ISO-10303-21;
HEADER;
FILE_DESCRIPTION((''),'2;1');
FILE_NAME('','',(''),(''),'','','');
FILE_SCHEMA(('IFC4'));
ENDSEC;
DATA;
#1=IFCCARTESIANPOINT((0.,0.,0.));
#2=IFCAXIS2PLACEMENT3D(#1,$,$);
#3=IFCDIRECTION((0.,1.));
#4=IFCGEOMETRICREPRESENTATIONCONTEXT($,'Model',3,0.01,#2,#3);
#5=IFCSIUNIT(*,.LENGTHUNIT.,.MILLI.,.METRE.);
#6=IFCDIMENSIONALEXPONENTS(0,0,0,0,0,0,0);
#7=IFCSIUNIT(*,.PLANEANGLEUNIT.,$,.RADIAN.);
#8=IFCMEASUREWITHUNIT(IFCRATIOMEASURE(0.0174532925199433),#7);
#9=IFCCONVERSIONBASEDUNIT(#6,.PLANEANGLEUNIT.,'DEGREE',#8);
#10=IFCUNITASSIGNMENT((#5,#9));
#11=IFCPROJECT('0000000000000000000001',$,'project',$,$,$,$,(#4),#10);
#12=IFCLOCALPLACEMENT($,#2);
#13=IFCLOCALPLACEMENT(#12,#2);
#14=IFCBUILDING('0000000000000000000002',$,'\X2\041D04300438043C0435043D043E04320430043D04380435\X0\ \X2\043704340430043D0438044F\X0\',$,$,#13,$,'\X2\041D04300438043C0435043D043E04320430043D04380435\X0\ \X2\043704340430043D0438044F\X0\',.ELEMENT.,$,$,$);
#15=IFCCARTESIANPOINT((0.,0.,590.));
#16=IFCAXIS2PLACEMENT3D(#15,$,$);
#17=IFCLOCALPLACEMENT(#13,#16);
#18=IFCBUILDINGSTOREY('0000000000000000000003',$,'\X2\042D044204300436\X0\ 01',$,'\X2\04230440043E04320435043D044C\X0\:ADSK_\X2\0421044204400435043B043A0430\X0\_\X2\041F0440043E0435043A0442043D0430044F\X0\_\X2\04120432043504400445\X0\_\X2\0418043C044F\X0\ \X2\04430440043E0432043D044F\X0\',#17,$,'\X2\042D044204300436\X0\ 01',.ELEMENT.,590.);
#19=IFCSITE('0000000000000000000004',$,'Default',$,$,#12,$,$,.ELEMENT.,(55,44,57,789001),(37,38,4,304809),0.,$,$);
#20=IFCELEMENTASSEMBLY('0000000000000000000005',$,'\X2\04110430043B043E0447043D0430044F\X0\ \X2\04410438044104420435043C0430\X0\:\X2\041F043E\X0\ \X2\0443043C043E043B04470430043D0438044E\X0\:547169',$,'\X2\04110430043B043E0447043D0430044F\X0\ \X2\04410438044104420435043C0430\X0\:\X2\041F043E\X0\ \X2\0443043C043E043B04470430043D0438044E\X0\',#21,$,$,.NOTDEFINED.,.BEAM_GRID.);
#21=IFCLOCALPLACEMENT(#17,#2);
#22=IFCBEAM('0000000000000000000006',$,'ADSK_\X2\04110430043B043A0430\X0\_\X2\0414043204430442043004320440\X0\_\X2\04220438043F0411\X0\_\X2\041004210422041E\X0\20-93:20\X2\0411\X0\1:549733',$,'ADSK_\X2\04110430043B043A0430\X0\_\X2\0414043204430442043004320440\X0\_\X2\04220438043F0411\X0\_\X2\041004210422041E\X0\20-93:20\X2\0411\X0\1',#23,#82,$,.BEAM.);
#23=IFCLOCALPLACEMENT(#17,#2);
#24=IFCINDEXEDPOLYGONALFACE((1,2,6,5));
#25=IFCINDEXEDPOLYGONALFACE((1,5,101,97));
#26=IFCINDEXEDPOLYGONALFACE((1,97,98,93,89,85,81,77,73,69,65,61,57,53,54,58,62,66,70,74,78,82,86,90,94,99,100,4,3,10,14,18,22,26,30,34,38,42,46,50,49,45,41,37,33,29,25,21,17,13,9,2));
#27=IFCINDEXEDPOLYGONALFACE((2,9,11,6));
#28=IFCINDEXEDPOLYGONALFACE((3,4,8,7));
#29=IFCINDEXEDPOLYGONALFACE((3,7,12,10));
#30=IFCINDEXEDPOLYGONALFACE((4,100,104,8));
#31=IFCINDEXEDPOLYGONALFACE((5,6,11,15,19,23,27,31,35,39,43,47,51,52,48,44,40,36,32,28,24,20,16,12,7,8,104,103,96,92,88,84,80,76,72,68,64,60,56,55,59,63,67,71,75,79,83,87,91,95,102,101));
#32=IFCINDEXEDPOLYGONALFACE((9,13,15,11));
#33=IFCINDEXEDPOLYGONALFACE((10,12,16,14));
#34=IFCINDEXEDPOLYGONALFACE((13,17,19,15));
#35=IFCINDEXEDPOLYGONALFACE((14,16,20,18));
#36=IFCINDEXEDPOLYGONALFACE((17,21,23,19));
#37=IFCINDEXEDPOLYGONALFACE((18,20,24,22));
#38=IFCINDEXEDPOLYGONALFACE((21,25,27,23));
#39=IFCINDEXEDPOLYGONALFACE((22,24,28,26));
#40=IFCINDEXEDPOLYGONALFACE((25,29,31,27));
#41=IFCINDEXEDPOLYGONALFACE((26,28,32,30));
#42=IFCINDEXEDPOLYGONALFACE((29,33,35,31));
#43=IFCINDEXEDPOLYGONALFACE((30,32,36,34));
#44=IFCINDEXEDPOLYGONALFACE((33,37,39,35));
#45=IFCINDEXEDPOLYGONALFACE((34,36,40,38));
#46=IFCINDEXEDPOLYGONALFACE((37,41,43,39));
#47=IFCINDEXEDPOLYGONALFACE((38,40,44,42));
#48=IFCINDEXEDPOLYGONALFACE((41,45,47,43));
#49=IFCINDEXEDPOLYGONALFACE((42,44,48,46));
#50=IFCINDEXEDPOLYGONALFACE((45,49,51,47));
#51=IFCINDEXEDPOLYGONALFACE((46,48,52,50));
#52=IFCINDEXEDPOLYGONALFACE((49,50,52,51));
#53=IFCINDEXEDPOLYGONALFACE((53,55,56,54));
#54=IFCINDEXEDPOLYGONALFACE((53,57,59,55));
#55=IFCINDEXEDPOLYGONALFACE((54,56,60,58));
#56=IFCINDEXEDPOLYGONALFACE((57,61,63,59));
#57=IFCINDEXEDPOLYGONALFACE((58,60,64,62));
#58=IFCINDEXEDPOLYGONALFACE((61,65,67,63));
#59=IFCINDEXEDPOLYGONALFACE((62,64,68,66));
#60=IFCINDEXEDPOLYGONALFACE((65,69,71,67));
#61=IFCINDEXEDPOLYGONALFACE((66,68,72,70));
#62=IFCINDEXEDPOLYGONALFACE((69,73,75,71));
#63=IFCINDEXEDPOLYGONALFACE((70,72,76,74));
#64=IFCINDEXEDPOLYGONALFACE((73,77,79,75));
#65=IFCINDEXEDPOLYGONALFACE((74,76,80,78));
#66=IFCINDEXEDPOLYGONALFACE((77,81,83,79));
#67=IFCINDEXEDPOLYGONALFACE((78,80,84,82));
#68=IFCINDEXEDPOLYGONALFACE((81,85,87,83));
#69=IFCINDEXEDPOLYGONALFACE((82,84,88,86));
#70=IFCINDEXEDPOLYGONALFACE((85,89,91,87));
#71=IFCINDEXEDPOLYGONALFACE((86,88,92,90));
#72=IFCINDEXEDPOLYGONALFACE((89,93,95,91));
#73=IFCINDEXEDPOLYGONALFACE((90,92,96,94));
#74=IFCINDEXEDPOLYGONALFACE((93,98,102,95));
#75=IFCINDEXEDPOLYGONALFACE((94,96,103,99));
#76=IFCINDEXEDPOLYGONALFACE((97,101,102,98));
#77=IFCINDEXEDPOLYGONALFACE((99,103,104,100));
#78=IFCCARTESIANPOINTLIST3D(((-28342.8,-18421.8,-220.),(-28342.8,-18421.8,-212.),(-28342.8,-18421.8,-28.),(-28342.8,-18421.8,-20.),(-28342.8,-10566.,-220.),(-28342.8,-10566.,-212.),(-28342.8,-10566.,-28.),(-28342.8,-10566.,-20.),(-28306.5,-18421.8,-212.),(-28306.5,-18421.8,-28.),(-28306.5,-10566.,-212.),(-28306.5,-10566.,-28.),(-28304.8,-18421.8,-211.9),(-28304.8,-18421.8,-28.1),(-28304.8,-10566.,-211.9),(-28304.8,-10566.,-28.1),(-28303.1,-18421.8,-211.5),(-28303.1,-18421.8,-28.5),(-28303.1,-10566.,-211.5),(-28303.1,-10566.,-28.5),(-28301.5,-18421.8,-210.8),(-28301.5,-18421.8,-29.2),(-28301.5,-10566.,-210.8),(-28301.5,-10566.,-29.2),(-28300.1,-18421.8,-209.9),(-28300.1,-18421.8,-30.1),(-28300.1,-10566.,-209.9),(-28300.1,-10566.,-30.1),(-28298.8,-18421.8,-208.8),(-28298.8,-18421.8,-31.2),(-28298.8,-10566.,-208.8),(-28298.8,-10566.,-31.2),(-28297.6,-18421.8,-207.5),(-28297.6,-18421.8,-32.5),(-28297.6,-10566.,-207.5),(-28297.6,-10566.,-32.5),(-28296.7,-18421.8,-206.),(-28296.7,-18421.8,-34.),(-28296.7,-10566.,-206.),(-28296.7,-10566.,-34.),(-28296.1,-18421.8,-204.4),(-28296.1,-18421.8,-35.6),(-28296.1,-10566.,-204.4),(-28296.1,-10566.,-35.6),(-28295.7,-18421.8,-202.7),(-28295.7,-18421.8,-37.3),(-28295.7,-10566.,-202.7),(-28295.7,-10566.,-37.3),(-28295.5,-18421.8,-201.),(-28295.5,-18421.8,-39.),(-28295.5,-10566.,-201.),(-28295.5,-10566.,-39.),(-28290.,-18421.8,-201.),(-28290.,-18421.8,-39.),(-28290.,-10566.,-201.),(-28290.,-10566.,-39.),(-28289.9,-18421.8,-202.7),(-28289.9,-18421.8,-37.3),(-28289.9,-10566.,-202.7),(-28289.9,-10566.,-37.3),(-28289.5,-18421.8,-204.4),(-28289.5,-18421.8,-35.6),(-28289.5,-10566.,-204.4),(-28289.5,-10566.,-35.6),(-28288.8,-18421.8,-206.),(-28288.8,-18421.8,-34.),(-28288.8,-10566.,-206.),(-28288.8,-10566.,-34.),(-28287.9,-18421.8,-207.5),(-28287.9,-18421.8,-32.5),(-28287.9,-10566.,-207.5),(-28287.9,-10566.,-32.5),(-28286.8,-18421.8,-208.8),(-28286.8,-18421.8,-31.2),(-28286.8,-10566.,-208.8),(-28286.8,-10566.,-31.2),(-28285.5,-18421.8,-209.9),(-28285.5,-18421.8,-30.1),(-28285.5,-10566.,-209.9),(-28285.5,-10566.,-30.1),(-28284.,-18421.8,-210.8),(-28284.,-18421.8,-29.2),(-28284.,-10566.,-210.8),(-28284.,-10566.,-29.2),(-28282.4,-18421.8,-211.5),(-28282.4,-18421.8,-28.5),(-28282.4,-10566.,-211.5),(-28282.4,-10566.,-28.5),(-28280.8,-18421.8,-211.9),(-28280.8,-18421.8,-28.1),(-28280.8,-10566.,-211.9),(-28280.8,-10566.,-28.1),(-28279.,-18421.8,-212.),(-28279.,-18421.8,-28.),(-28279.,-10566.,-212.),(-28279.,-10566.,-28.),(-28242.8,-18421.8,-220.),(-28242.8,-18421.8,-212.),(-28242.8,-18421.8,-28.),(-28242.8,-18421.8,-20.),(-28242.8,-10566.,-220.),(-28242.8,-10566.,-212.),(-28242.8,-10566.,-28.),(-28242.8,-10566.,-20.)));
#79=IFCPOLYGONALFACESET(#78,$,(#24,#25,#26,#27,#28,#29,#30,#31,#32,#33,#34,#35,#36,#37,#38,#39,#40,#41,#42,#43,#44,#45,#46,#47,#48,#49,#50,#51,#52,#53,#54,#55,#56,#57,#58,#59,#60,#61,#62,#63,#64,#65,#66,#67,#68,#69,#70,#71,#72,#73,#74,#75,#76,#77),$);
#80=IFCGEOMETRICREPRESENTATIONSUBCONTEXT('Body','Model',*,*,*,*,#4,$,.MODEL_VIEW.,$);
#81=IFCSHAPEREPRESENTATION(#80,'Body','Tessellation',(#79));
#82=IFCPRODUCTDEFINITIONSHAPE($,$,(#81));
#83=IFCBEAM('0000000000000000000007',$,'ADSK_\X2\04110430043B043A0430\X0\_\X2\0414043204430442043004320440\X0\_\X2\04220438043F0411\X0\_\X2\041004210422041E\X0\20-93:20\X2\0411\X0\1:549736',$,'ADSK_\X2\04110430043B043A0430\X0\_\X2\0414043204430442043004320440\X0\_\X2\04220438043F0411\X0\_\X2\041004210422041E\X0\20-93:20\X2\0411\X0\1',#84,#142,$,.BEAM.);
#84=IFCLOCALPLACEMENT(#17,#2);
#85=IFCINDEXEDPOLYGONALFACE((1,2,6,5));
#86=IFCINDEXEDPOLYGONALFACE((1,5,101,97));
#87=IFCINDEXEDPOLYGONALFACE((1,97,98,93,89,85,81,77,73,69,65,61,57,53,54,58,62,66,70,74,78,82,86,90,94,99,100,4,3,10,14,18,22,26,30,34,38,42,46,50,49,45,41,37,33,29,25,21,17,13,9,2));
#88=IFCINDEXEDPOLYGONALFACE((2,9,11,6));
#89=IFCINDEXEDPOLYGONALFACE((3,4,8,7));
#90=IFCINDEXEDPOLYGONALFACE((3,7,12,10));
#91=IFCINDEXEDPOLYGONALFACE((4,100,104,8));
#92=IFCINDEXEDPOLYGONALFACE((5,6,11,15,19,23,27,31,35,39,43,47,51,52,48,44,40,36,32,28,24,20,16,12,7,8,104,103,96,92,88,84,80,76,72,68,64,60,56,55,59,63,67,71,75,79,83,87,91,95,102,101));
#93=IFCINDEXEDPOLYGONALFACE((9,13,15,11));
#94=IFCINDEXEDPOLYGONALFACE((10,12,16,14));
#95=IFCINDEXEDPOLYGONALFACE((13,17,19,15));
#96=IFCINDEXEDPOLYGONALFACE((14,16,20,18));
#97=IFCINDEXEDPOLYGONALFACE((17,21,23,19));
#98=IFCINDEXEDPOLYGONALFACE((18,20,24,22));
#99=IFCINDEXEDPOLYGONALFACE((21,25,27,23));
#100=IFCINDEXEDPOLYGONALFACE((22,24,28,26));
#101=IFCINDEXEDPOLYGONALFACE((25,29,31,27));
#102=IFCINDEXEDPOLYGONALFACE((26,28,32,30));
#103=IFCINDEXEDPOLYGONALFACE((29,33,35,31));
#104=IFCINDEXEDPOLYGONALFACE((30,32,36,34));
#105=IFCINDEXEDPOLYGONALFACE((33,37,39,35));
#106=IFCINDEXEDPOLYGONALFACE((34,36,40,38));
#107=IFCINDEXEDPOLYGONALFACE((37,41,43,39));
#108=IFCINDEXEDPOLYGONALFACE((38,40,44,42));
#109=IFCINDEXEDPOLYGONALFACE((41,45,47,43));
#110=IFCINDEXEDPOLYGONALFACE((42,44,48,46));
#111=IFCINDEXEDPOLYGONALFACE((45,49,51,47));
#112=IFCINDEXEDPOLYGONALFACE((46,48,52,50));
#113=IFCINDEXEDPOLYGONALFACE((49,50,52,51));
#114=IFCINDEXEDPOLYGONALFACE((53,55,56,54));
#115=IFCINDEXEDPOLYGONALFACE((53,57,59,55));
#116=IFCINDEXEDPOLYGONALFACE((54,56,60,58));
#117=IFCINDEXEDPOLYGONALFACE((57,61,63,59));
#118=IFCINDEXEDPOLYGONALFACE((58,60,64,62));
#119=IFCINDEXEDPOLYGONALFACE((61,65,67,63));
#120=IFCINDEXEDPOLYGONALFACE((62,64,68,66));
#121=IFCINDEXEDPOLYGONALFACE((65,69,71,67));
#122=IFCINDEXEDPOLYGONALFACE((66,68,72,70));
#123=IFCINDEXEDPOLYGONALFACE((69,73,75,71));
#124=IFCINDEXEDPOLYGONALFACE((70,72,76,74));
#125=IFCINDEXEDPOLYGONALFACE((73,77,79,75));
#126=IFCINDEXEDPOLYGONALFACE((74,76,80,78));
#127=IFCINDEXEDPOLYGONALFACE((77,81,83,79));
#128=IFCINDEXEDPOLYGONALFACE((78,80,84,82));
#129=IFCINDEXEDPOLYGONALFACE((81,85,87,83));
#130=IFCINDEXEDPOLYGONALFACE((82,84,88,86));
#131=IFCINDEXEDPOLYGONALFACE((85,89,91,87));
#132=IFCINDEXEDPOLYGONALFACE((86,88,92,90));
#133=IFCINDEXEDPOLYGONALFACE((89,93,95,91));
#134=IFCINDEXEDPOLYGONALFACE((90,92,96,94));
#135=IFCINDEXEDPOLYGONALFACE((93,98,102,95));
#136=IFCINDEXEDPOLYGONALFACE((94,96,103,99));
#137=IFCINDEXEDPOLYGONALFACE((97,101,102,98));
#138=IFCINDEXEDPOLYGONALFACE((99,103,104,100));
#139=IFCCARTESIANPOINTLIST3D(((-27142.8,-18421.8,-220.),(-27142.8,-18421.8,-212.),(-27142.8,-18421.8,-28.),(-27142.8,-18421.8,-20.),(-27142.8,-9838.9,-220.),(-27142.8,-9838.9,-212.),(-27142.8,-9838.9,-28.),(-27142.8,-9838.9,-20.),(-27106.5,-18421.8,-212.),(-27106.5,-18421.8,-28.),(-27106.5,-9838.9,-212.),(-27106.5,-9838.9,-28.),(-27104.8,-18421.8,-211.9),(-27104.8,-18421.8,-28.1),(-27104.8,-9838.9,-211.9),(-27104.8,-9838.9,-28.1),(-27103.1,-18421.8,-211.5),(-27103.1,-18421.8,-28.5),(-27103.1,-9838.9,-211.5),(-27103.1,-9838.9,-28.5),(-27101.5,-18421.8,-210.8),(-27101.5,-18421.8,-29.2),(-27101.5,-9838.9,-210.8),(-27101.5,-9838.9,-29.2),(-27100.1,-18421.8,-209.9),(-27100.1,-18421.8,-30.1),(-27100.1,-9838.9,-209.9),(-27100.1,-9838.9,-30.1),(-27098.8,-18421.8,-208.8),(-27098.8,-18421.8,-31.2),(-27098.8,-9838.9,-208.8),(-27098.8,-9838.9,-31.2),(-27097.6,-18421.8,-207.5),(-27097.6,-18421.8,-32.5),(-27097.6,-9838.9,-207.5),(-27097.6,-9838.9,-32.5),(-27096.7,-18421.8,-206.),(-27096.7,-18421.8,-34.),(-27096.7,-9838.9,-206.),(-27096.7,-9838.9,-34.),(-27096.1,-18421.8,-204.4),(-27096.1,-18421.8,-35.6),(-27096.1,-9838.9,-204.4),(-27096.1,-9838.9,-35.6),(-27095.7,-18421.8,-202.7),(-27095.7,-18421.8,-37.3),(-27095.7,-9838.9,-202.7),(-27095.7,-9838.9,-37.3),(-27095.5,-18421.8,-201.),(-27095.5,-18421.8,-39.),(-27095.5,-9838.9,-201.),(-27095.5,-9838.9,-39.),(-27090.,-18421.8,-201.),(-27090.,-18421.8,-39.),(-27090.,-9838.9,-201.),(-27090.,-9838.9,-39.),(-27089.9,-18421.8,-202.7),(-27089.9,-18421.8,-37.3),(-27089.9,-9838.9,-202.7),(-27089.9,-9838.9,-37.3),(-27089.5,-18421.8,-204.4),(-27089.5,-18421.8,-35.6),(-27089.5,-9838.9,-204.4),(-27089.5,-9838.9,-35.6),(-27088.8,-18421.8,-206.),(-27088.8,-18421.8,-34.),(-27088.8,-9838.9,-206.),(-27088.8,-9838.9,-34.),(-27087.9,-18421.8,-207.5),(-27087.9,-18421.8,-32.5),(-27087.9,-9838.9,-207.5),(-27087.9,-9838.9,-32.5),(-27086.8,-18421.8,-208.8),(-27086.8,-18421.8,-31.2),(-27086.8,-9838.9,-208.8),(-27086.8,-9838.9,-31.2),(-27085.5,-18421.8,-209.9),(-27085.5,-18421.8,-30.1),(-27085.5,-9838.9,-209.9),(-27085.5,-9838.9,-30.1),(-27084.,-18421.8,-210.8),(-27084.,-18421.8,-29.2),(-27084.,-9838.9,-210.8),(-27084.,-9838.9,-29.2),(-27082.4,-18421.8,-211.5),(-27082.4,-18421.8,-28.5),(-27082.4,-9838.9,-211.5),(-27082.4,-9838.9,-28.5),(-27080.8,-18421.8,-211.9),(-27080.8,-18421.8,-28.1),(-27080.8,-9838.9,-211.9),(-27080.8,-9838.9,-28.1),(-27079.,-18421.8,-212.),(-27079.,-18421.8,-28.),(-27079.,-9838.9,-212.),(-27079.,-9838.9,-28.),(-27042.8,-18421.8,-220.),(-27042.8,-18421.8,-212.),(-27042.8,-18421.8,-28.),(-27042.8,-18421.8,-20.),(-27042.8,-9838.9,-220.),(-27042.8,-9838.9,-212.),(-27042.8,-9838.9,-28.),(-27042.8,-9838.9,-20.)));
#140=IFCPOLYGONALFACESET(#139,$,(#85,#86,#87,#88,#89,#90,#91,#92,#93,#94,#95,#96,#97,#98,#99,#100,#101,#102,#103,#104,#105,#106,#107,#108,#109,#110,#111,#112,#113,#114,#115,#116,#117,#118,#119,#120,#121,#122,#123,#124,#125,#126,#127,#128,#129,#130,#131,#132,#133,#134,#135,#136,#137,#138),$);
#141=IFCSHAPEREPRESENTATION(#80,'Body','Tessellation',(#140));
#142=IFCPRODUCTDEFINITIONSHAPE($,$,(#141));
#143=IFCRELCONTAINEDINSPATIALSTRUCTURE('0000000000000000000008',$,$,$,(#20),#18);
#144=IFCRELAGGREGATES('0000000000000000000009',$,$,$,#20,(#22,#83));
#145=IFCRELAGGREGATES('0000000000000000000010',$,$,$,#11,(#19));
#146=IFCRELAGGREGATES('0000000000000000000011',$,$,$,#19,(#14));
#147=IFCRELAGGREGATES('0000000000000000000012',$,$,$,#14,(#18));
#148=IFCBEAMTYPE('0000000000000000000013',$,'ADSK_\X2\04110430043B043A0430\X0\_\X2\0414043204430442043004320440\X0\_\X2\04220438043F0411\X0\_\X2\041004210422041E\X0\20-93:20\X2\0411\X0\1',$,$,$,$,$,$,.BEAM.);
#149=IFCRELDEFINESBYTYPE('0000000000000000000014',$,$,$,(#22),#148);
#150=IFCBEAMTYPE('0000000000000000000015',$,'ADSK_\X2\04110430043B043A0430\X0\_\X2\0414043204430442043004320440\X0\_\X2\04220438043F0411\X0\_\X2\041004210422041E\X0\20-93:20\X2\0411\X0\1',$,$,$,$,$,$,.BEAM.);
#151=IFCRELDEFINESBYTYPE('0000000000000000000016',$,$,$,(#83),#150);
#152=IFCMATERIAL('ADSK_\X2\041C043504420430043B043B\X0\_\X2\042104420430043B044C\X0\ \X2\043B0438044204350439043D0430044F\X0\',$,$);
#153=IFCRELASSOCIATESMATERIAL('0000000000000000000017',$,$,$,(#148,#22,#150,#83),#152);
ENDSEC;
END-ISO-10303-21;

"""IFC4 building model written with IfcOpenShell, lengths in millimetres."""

from ifc_helpers import new_model, entity, si_unit, converted_unit, direction, frame, origin, place, context, subcontext, project, spatial, indexed_curve, outline, extrude, source, transform, mapped, material, type_object, type_shapes, element, aggregate, save


model = new_model("IFC4")

# Units and contexts
model_context = context("Model", 3, precision=0.01, world=origin(), true_north=direction((0.0, 1.0)))
body_context = subcontext(model_context, "Body", "Model", "MODEL_VIEW")
ifc_project = project(units=[si_unit("LENGTHUNIT", "METRE", prefix="MILLI"), converted_unit("PLANEANGLEUNIT", "DEGREE", entity("IfcRatioMeasure", 0.0174532925199433), si_unit("PLANEANGLEUNIT", "RADIAN"), dimensions=[0, 0, 0, 0, 0, 0, 0])], contexts=[model_context])

# Site, building, storey
site_placement = place(None, origin())
site = spatial("IfcSite", under=ifc_project, at=site_placement, Name="Default", CompositionType="ELEMENT", RefLatitude=(55, 44, 57, 789001), RefLongitude=(37, 38, 4, 304809), RefElevation=0.0)
building_placement = place(site_placement, origin())
building = spatial("IfcBuilding", under=site, at=building_placement, Name="Наименование здания", LongName="Наименование здания", CompositionType="ELEMENT")
storey_placement = place(building_placement, frame((0.0, 0.0, 590.0)))
storey = spatial("IfcBuildingStorey", under=building, at=storey_placement, Name="Этаж 01", ObjectType="Уровень:ADSK_Стрелка_Проектная_Вверх_Имя уровня", LongName="Этаж 01", CompositionType="ELEMENT", Elevation=590.0)

# Element assembly, beams
assembly_placement = place(storey_placement, origin())
assembly = element("IfcElementAssembly", 1, at=assembly_placement, inside=storey, Name="Балочная система:По умолчанию:547169", ObjectType="Балочная система:По умолчанию", AssemblyPlace="NOTDEFINED", PredefinedType="BEAM_GRID")
ifc_material_1 = material(Name="ADSK_Металл_Сталь литейная")
beam_type_1 = type_object("IfcBeamType", Name="ADSK_Балка_Двутавр_ТипБ_АСТО20-93:20Б1", PredefinedType="BEAM", material=ifc_material_1)
shared_shape_1 = source(origin(), body_context, "Body", "SweptSolid", [
    extrude(outline(indexed_curve([(-100.0, -50.0), (-92.0, -50.0), (-92.0, -13.8), (-91.9, -12.0), (-91.5, -10.4), (-90.8, -8.8), (-89.9, -7.3), (-88.8, -6.0), (-87.5, -4.9), (-86.0, -3.9), (-84.4, -3.3), (-82.7, -2.9), (-81.0, -2.8), (81.0, -2.8), (82.7, -2.9), (84.4, -3.3), (86.0, -3.9), (87.5, -4.9), (88.8, -6.0), (89.9, -7.3), (90.8, -8.8), (91.5, -10.4), (91.9, -12.0), (92.0, -13.7), (92.0, -50.0), (100.0, -50.0), (100.0, 50.0), (92.0, 50.0), (92.0, 13.8), (91.9, 12.0), (91.5, 10.4), (90.8, 8.8), (89.9, 7.3), (88.8, 6.0), (87.5, 4.9), (86.0, 3.9), (84.4, 3.3), (82.7, 2.9), (81.0, 2.8), (-81.0, 2.8), (-82.7, 2.9), (-84.4, 3.3), (-86.0, 3.9), (-87.5, 4.9), (-88.8, 6.0), (-89.9, 7.3), (-90.8, 8.8), (-91.5, 10.4), (-91.9, 12.0), (-92.0, 13.8), (-92.0, 50.0), (-100.0, 50.0), (-100.0, -50.0)], self_intersect=False)), frame((-3927.9, 0.0, -100.0), z_axis=(1.0, 0.0, 0.0), x_axis=(0.0, 0.0, -1.0)), (0.0, 0.0, 1.0), 7855.8),
])
type_shapes(beam_type_1, [shared_shape_1])
beam_1_placement = place(assembly_placement, frame((-28292.8, -14493.9, -20.0), z_axis=(0.0, 0.0, 1.0), x_axis=(0.0, 1.0, 0.0)))
beam_1 = element("IfcBeam", 2, at=beam_1_placement, type_object=beam_type_1, material=ifc_material_1, Name="ADSK_Балка_Двутавр_ТипБ_АСТО20-93:20Б1:549733", ObjectType="ADSK_Балка_Двутавр_ТипБ_АСТО20-93:20Б1", PredefinedType="BEAM", context=body_context, shape_type="MappedRepresentation", body=[
    mapped(shared_shape_1, transform((0.0, 0.0, 0.0), scale=1.0)),
])
beam_type_2 = type_object("IfcBeamType", Name="ADSK_Балка_Двутавр_ТипБ_АСТО20-93:20Б1", PredefinedType="BEAM", material=ifc_material_1)
shared_shape_2 = source(origin(), body_context, "Body", "SweptSolid", [
    extrude(outline(indexed_curve([(-100.0, -50.0), (-92.0, -50.0), (-92.0, -13.8), (-91.9, -12.0), (-91.5, -10.4), (-90.8, -8.8), (-89.9, -7.3), (-88.8, -6.0), (-87.5, -4.9), (-86.0, -3.9), (-84.4, -3.3), (-82.7, -2.9), (-81.0, -2.8), (81.0, -2.8), (82.7, -2.9), (84.4, -3.3), (86.0, -3.9), (87.5, -4.9), (88.8, -6.0), (89.9, -7.3), (90.8, -8.8), (91.5, -10.4), (91.9, -12.0), (92.0, -13.7), (92.0, -50.0), (100.0, -50.0), (100.0, 50.0), (92.0, 50.0), (92.0, 13.8), (91.9, 12.0), (91.5, 10.4), (90.8, 8.8), (89.9, 7.3), (88.8, 6.0), (87.5, 4.9), (86.0, 3.9), (84.4, 3.3), (82.7, 2.9), (81.0, 2.8), (-81.0, 2.8), (-82.7, 2.9), (-84.4, 3.3), (-86.0, 3.9), (-87.5, 4.9), (-88.8, 6.0), (-89.9, 7.3), (-90.8, 8.8), (-91.5, 10.4), (-91.9, 12.0), (-92.0, 13.8), (-92.0, 50.0), (-100.0, 50.0), (-100.0, -50.0)], self_intersect=False)), frame((-4291.4, 0.0, -100.0), z_axis=(1.0, 0.0, 0.0), x_axis=(0.0, 0.0, -1.0)), (0.0, 0.0, 1.0), 8582.9),
])
type_shapes(beam_type_2, [shared_shape_2])
beam_2_placement = place(assembly_placement, frame((-27092.8, -14130.4, -20.0), z_axis=(0.0, 0.0, 1.0), x_axis=(0.0, 1.0, 0.0)))
beam_2 = element("IfcBeam", 3, at=beam_2_placement, type_object=beam_type_2, material=ifc_material_1, Name="ADSK_Балка_Двутавр_ТипБ_АСТО20-93:20Б1:549736", ObjectType="ADSK_Балка_Двутавр_ТипБ_АСТО20-93:20Б1", PredefinedType="BEAM", context=body_context, shape_type="MappedRepresentation", body=[
    mapped(shared_shape_2, transform((0.0, 0.0, 0.0), scale=1.0)),
])
aggregate(assembly, [beam_1, beam_2])

save(model, "model.ifc")
